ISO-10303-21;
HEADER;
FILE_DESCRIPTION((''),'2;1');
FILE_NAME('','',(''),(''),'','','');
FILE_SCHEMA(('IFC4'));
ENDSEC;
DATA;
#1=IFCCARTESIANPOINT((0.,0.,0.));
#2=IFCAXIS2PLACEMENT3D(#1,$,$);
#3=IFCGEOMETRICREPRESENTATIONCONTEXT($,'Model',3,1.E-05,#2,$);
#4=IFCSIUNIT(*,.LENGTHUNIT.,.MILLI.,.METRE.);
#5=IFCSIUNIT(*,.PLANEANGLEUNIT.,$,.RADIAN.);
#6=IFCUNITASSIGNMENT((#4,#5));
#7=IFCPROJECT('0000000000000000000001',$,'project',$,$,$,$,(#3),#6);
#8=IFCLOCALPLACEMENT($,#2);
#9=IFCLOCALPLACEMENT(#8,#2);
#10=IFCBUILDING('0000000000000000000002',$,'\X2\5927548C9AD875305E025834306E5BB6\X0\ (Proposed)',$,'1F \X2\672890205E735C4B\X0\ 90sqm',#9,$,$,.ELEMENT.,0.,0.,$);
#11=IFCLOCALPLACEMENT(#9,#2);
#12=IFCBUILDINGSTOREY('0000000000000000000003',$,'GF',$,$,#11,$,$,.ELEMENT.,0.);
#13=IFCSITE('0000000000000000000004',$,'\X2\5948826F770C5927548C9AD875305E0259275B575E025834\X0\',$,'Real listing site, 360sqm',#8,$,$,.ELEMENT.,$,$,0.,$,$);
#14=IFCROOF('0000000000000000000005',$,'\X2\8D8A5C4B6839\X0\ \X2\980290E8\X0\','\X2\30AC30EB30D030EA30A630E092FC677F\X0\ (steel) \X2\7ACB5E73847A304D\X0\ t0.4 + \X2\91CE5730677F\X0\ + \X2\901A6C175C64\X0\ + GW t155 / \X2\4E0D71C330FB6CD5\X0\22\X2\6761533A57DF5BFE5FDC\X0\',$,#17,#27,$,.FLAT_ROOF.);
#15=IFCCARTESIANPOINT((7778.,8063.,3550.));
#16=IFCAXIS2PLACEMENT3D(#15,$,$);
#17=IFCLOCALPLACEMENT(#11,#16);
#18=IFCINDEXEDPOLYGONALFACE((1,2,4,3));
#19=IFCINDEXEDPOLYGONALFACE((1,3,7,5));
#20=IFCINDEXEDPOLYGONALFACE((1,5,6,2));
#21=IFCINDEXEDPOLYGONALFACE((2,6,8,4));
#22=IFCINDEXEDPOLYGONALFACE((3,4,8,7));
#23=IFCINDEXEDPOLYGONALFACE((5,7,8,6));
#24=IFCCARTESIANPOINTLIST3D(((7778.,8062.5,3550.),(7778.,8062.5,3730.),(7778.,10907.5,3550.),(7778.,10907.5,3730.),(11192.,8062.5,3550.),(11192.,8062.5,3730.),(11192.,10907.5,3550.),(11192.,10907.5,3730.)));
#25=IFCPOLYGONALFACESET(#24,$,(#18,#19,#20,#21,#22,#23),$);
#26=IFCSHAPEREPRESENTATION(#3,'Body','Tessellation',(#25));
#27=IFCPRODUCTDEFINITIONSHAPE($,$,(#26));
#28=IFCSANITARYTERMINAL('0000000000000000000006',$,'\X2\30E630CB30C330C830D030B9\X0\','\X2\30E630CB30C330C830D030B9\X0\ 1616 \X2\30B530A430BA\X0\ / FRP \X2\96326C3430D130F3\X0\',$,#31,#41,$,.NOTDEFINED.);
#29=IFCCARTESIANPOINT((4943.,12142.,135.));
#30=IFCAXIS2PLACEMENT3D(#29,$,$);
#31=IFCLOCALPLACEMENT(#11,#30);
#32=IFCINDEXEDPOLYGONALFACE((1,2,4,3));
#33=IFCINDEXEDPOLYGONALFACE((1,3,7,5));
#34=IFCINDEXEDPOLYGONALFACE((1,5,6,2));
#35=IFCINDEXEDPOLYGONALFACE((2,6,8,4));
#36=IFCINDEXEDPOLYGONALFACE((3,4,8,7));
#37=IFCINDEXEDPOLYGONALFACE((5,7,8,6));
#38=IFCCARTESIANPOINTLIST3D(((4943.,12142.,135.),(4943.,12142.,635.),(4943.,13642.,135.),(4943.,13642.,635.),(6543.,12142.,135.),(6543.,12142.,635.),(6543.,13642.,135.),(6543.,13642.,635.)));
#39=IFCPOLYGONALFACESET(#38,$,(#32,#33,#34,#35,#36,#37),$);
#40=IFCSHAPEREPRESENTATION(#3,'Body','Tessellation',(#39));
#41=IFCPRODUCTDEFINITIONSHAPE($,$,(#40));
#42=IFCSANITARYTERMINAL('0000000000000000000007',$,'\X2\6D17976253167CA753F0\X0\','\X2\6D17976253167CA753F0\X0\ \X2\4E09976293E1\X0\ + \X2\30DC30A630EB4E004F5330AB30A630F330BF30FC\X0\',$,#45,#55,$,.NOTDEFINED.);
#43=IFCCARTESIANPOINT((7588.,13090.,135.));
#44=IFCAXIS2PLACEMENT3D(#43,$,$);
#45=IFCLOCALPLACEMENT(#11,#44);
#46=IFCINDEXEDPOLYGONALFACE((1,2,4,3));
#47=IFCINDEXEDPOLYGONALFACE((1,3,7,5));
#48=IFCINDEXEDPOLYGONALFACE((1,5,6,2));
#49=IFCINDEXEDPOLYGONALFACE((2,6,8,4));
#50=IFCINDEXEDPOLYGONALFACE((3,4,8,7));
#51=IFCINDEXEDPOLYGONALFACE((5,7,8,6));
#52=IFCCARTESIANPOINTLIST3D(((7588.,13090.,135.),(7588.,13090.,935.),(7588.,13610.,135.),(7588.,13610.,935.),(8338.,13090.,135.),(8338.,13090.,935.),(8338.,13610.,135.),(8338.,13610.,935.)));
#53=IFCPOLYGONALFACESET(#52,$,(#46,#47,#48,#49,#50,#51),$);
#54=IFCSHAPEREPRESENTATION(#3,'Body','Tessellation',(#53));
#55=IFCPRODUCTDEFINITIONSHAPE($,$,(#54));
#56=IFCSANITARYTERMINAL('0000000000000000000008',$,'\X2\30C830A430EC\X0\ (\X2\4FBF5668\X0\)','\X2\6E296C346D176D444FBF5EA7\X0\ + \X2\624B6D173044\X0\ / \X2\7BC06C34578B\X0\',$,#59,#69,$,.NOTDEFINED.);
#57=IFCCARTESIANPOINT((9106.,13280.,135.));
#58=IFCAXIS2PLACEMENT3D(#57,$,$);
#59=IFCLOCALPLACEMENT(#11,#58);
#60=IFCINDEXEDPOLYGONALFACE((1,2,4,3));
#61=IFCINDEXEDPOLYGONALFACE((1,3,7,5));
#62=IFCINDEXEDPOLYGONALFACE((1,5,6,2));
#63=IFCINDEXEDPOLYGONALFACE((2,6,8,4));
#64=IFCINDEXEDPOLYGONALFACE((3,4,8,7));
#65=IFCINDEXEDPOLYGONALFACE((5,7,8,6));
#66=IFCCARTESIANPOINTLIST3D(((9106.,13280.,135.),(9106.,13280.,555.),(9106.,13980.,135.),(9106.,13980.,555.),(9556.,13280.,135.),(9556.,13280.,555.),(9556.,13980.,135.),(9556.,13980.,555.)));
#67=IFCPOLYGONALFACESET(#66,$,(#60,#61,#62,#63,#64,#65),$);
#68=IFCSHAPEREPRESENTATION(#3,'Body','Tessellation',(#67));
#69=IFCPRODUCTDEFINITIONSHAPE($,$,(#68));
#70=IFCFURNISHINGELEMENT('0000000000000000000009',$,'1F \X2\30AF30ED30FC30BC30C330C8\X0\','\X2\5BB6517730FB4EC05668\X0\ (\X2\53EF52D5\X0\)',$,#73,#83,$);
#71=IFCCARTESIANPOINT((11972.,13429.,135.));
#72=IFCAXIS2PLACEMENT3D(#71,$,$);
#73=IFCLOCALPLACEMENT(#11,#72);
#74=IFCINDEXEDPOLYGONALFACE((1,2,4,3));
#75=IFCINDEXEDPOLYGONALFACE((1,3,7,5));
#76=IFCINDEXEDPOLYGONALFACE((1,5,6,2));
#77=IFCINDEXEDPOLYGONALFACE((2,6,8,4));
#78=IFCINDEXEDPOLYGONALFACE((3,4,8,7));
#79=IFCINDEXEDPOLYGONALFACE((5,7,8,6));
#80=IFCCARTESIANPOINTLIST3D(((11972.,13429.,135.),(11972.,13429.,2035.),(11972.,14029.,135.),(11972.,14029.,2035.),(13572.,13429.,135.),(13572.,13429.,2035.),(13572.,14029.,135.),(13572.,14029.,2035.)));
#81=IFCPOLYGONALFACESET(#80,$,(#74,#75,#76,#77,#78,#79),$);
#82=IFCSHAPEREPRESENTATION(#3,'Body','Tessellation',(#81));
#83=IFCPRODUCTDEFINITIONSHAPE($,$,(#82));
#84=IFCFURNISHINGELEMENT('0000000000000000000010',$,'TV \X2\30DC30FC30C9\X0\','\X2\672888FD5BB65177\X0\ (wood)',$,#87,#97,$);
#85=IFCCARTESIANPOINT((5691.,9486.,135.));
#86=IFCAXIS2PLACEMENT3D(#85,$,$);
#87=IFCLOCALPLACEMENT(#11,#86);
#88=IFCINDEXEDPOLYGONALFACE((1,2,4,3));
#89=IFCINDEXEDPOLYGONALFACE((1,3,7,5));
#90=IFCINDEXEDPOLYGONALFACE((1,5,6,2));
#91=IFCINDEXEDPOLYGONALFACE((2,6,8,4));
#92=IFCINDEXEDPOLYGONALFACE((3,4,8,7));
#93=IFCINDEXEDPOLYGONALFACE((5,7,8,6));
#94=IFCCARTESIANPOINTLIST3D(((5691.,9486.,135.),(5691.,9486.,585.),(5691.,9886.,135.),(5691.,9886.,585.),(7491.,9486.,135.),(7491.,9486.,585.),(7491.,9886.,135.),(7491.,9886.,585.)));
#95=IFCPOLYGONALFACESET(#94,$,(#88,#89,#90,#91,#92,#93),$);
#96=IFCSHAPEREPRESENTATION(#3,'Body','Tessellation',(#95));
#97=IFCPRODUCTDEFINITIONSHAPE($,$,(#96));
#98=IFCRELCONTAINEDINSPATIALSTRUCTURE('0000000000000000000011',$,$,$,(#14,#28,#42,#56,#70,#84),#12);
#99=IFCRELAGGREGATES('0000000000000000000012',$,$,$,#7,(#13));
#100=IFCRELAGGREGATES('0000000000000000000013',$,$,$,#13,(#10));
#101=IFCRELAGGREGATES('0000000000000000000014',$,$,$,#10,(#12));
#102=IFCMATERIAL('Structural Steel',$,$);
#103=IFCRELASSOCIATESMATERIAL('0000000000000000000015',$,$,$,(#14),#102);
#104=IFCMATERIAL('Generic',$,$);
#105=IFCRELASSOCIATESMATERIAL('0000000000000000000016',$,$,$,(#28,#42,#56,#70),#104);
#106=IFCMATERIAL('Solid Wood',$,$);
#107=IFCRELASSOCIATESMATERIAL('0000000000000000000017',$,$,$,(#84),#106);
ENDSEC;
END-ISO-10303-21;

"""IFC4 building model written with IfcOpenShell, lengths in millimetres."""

from ifc_helpers import new_model, si_unit, frame, frame_2d, origin, place, context, project, spatial, rectangle, extrude, material, element, save


model = new_model("IFC4")

# Units and contexts
model_context = context("Model", 3, precision=1e-05, world=origin())
ifc_project = project(units=[si_unit("LENGTHUNIT", "METRE", prefix="MILLI"), si_unit("PLANEANGLEUNIT", "RADIAN")], contexts=[model_context])

# Site, building, storey
site_placement = place(None, origin())
site = spatial("IfcSite", under=ifc_project, at=site_placement, Name="奈良県大和高田市大字市場", ObjectType="Real listing site, 360sqm", CompositionType="ELEMENT", RefElevation=0.0)
building_placement = place(site_placement, origin())
building = spatial("IfcBuilding", under=site, at=building_placement, Name="大和高田市場の家 (Proposed)", ObjectType="1F 木造平屋 90sqm", CompositionType="ELEMENT", ElevationOfRefHeight=0.0, ElevationOfTerrain=0.0)
storey_placement = place(building_placement, origin())
storey = spatial("IfcBuildingStorey", under=building, at=storey_placement, Name="GF", CompositionType="ELEMENT", Elevation=0.0)

# Shared definitions
ifc_material_1 = material(Name="Solid Wood")

# Roof
ifc_material_2 = material(Name="Structural Steel")
roof_placement = place(storey_placement, frame((7778.0, 8063.0, 3550.0)))
element("IfcRoof", 1, at=roof_placement, inside=storey, material=ifc_material_2, Name="越屋根 頂部", Description="ガルバリウム鋼板 (steel) 立平葺き t0.4 + 野地板 + 通気層 + GW t155 / 不燃・法22条区域対応", PredefinedType="FLAT_ROOF", context=model_context, shape_type="SweptSolid", body=[
    extrude(rectangle(XDim=3414.0, YDim=2845.0, at=frame_2d((1707.0, 1422.0))), frame((7778.0, 8063.0, 3550.0)), (0.0, 0.0, 1.0), 180.0),
])

# Sanitary terminals
ifc_material_3 = material(Name="Generic")
sanitary_terminal_1_placement = place(storey_placement, frame((4943.0, 12142.0, 135.0)))
element("IfcSanitaryTerminal", 2, at=sanitary_terminal_1_placement, inside=storey, material=ifc_material_3, Name="ユニットバス", Description="ユニットバス 1616 サイズ / FRP 防水パン", PredefinedType="NOTDEFINED", context=model_context, shape_type="SweptSolid", body=[
    extrude(rectangle(XDim=1600.0, YDim=1500.0, at=frame_2d((800.0, 750.0))), frame((4943.0, 12142.0, 135.0)), (0.0, 0.0, 1.0), 500.0),
])
sanitary_terminal_2_placement = place(storey_placement, frame((7588.0, 13090.0, 135.0)))
element("IfcSanitaryTerminal", 3, at=sanitary_terminal_2_placement, inside=storey, material=ifc_material_3, Name="洗面化粧台", Description="洗面化粧台 三面鏡 + ボウル一体カウンター", PredefinedType="NOTDEFINED", context=model_context, shape_type="SweptSolid", body=[
    extrude(rectangle(XDim=750.0, YDim=520.0, at=frame_2d((375.0, 260.0))), frame((7588.0, 13090.0, 135.0)), (0.0, 0.0, 1.0), 800.0),
])
sanitary_terminal_3_placement = place(storey_placement, frame((9106.0, 13280.0, 135.0)))
element("IfcSanitaryTerminal", 4, at=sanitary_terminal_3_placement, inside=storey, material=ifc_material_3, Name="トイレ (便器)", Description="温水洗浄便座 + 手洗い / 節水型", PredefinedType="NOTDEFINED", context=model_context, shape_type="SweptSolid", body=[
    extrude(rectangle(XDim=450.0, YDim=700.0, at=frame_2d((225.0, 350.0))), frame((9106.0, 13280.0, 135.0)), (0.0, 0.0, 1.0), 420.0),
])

# Furnishing elements
furnishing_1_placement = place(storey_placement, frame((11972.0, 13429.0, 135.0)))
element("IfcFurnishingElement", 5, at=furnishing_1_placement, inside=storey, material=ifc_material_3, Name="1F クローゼット", Description="家具・什器 (可動)", context=model_context, shape_type="SweptSolid", body=[
    extrude(rectangle(XDim=1600.0, YDim=600.0, at=frame_2d((800.0, 300.0))), frame((11972.0, 13429.0, 135.0)), (0.0, 0.0, 1.0), 1900.0),
])
furnishing_2_placement = place(storey_placement, frame((5691.0, 9486.0, 135.0)))
element("IfcFurnishingElement", 6, at=furnishing_2_placement, inside=storey, material=ifc_material_1, Name="TV ボード", Description="木製家具 (wood)", context=model_context, shape_type="SweptSolid", body=[
    extrude(rectangle(XDim=1800.0, YDim=400.0, at=frame_2d((900.0, 200.0))), frame((5691.0, 9486.0, 135.0)), (0.0, 0.0, 1.0), 450.0),
])

save(model, "model.ifc")
